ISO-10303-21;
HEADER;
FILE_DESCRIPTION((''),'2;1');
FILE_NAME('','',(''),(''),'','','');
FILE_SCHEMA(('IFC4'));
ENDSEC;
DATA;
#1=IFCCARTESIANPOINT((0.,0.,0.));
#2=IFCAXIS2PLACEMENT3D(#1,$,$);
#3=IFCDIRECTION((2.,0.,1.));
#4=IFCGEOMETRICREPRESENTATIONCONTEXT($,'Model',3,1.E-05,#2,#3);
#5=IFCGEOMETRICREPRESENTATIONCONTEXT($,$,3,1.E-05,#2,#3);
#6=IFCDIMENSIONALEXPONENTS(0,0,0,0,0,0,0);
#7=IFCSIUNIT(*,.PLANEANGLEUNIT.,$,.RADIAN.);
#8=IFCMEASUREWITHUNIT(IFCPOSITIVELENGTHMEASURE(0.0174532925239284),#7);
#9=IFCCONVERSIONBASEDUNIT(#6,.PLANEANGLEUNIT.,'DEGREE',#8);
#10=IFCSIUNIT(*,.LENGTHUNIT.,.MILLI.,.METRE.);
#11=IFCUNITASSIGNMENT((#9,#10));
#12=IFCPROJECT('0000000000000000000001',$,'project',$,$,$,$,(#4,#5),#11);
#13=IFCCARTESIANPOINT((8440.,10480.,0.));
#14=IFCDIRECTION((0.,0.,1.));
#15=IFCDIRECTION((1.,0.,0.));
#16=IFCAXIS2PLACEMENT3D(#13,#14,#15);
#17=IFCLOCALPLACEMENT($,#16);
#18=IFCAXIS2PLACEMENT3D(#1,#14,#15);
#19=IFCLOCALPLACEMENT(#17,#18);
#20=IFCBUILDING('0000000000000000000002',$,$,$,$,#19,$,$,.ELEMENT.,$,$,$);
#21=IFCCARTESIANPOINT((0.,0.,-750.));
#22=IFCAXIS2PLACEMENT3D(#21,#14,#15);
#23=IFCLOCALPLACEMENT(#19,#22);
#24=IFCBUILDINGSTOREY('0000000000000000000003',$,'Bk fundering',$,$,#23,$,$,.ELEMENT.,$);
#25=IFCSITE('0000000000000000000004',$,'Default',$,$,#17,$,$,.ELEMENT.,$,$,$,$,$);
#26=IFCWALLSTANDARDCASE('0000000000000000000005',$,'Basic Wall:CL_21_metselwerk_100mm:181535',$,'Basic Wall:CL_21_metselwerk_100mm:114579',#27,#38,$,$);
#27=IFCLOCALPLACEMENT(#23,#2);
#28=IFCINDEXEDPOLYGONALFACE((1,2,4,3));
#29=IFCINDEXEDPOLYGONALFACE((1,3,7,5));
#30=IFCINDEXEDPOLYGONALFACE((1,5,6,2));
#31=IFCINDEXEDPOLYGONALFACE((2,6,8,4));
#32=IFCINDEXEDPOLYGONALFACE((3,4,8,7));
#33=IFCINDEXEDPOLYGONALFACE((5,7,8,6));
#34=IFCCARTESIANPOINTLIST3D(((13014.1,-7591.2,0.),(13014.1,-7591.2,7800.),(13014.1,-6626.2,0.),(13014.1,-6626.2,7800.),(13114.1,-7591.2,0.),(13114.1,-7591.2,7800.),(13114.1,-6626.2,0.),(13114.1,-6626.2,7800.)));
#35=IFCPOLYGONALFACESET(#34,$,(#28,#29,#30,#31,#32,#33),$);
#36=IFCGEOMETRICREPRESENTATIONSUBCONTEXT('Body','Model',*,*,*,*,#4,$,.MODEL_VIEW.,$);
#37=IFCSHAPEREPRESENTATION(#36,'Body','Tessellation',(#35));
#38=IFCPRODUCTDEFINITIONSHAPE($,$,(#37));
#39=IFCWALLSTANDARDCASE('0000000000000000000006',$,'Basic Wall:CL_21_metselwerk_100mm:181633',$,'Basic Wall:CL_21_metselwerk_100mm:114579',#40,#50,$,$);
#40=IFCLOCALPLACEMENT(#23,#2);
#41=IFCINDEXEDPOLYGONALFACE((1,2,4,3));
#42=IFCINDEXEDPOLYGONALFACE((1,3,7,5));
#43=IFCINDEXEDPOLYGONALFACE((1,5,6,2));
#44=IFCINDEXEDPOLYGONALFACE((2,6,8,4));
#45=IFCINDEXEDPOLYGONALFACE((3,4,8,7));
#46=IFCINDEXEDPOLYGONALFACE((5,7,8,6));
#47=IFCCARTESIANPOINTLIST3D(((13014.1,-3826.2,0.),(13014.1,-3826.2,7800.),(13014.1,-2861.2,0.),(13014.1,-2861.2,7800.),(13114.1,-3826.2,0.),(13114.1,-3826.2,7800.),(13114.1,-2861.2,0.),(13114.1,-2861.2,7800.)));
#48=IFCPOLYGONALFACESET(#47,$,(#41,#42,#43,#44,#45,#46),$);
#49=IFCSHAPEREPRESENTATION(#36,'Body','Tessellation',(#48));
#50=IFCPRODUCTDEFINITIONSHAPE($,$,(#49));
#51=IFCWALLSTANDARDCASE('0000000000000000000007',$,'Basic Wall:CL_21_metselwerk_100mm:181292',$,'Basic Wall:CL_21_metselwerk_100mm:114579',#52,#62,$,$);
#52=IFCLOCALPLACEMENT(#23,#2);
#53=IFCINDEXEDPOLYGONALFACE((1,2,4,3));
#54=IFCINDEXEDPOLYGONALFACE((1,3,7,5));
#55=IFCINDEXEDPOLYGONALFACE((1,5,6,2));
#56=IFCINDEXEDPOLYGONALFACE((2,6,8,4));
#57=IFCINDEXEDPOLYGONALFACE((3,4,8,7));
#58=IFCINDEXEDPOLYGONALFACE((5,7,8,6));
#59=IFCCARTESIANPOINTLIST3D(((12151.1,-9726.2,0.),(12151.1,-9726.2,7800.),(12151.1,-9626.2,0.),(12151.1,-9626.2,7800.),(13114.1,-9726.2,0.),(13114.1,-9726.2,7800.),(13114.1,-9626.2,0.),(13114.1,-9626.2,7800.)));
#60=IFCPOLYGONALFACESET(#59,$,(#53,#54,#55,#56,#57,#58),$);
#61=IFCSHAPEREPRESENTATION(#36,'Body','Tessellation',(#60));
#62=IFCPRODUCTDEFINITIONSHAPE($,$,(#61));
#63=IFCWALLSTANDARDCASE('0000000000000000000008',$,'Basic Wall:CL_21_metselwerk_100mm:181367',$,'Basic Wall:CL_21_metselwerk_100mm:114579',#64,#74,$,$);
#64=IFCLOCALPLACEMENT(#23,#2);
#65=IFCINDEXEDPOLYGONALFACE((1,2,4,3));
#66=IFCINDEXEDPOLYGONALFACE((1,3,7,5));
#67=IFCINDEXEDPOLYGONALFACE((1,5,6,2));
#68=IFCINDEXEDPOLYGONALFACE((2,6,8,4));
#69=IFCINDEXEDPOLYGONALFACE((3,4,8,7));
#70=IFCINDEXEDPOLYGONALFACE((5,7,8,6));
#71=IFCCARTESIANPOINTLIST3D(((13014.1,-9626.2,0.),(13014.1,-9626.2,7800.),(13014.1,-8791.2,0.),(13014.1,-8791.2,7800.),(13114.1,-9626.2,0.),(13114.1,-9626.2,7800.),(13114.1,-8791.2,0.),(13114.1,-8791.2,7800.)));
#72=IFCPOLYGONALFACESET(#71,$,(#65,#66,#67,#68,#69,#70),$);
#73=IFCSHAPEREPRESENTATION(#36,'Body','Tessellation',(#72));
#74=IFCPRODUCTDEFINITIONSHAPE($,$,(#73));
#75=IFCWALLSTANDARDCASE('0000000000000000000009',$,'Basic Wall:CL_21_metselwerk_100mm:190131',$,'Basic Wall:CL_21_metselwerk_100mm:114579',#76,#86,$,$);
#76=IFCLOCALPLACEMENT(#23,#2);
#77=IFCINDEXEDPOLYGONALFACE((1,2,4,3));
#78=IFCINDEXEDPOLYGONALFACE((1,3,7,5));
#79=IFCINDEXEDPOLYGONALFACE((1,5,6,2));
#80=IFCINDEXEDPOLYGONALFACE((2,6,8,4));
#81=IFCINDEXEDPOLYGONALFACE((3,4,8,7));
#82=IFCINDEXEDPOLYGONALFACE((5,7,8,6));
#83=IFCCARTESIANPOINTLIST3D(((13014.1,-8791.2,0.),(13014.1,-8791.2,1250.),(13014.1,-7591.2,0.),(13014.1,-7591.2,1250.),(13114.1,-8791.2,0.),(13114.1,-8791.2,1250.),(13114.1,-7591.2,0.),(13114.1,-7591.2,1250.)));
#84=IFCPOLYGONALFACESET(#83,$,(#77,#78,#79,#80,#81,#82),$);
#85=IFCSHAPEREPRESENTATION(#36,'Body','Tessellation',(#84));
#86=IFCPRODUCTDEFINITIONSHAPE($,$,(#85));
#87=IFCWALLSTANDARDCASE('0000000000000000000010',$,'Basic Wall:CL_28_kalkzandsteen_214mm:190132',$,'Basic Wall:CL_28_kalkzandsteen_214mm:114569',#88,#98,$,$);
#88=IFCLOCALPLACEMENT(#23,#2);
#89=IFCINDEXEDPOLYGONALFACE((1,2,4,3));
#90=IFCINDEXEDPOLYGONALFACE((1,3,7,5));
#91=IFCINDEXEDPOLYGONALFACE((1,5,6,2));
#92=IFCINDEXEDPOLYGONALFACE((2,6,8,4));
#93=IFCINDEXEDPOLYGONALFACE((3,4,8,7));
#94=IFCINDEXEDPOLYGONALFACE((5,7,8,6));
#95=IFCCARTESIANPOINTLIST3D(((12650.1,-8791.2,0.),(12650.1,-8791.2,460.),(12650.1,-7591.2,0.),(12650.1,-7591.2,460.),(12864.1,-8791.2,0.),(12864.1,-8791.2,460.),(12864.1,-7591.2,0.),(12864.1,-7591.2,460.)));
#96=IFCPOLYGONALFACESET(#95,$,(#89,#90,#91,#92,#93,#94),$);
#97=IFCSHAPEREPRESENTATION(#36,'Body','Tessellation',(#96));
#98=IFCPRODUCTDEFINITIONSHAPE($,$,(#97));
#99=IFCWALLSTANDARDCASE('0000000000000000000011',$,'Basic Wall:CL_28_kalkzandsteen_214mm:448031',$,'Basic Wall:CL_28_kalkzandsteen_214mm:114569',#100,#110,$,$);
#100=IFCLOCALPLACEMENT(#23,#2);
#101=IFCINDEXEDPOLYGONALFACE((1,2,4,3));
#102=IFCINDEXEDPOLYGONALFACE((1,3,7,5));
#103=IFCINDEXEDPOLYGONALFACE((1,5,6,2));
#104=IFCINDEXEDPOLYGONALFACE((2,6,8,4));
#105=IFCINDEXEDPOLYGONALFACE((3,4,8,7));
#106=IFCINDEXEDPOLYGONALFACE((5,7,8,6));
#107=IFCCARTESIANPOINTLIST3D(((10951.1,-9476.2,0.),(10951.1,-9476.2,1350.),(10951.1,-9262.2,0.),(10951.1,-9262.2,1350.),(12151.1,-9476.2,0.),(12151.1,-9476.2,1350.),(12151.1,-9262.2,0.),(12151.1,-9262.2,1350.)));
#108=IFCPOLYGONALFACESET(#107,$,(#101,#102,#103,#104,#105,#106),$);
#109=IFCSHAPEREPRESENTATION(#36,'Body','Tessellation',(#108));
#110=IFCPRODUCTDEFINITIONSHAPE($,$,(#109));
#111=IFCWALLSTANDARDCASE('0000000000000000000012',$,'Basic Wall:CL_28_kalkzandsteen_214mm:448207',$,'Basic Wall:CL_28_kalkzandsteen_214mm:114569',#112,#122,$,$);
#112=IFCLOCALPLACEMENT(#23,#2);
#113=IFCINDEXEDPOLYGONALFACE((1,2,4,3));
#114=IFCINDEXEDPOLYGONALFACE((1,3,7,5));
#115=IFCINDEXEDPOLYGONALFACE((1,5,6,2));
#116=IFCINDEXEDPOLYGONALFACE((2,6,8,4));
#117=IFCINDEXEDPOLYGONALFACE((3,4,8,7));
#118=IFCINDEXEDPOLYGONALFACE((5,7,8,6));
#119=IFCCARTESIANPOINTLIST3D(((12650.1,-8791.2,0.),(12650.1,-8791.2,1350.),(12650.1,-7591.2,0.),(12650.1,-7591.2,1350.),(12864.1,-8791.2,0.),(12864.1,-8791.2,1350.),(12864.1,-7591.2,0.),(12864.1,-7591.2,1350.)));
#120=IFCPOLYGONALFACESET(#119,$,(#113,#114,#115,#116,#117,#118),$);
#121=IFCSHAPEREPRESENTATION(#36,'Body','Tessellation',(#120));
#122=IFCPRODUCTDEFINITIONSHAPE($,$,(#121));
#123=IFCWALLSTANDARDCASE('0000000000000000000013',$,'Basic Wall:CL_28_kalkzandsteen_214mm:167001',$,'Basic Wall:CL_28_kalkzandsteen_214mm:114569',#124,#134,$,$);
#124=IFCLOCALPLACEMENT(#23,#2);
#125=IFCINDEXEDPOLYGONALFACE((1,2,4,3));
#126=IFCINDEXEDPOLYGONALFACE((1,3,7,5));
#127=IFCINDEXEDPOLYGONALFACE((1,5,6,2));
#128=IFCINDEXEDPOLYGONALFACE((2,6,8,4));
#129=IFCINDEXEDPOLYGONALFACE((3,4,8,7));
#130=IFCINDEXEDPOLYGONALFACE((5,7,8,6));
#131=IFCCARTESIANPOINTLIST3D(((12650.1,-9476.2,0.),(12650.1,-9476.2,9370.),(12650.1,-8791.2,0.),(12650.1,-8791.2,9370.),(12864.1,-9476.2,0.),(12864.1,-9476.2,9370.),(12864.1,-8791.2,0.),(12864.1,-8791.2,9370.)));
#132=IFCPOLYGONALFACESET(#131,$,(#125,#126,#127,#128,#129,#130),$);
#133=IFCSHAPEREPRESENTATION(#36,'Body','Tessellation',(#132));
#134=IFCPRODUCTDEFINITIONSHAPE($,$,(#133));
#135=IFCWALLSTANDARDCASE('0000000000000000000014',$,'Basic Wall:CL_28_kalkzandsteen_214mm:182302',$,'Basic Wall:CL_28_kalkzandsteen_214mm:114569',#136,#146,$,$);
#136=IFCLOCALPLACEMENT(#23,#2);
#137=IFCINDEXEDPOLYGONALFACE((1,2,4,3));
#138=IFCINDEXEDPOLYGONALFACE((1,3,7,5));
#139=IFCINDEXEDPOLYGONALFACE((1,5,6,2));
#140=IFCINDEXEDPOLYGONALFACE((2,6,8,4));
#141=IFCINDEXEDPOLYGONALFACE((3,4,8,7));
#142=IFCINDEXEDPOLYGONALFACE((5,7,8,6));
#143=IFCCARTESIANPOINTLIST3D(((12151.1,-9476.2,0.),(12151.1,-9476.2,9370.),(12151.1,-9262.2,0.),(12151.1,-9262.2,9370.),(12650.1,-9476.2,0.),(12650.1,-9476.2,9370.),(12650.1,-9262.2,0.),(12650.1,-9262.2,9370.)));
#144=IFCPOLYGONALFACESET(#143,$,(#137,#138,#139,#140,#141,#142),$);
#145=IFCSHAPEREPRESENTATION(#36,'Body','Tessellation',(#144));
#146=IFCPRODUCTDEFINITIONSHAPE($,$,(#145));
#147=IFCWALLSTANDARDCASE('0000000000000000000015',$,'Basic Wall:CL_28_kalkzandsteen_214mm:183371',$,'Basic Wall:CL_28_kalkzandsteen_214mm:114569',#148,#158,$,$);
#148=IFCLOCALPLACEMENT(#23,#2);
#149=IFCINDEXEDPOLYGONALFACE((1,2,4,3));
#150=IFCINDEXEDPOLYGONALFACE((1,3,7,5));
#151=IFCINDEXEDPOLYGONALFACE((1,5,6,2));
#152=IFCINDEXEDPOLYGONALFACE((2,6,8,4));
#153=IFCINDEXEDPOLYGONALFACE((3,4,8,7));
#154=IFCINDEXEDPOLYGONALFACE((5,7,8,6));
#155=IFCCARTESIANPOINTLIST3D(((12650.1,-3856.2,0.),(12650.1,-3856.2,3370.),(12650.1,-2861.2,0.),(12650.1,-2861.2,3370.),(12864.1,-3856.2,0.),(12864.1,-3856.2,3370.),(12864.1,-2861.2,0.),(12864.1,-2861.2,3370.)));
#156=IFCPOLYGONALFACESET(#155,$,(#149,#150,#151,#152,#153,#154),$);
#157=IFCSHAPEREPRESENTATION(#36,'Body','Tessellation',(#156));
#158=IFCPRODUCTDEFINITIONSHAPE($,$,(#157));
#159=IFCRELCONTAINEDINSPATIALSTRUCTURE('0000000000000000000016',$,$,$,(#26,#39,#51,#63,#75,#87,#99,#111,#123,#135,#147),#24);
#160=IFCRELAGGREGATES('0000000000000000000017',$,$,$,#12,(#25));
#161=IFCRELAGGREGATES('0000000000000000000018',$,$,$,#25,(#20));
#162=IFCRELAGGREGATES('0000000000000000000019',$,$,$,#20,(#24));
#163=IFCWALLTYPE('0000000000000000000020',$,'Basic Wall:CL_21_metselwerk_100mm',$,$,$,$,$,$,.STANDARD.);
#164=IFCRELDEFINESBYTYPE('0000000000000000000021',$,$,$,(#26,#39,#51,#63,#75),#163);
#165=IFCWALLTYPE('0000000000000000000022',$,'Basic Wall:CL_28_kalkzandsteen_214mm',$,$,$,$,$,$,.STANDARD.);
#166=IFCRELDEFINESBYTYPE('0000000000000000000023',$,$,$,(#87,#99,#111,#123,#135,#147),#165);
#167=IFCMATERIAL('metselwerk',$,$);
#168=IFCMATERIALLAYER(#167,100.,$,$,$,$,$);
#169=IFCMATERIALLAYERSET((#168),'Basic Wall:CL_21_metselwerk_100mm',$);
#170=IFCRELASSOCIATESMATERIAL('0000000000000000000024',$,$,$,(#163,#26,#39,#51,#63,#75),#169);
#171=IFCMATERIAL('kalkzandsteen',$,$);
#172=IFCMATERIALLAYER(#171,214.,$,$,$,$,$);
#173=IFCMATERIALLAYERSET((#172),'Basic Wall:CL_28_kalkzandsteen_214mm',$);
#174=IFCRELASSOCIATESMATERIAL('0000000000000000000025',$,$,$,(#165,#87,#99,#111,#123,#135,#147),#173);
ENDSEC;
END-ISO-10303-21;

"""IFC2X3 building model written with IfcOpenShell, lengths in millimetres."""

from ifc_helpers import new_model, entity, si_unit, converted_unit, direction, frame, frame_2d, origin, origin_with_axes, place, context, subcontext, project, spatial, polyline, rectangle, extrude, clip, bounded_halfspace, source, transform, mapped, material, layer, layer_set, layer_usage, type_object, element, save


model = new_model("IFC2X3")

# Units and contexts
model_context = context("Model", 3, precision=1e-05, world=origin(), true_north=direction((2.0, 0.0, 1.0)))
context_of_model = context(None, 3, precision=1e-05, world=origin(), true_north=direction((2.0, 0.0, 1.0)))
body_context = subcontext(model_context, "Body", "Model", "MODEL_VIEW")
ifc_project = project(units=[converted_unit("PLANEANGLEUNIT", "DEGREE", entity("IfcPositiveLengthMeasure", 0.0174532925239284), si_unit("PLANEANGLEUNIT", "RADIAN"), dimensions=[0, 0, 0, 0, 0, 0, 0]), si_unit("LENGTHUNIT", "METRE", prefix="MILLI")], contexts=[model_context, context_of_model])

# Site, building, storey
site_placement = place(None, frame((8440.0, 10480.0, 0.0), z_axis=(0.0, 0.0, 1.0), x_axis=(1.0, 0.0, 0.0)))
site = spatial("IfcSite", under=ifc_project, at=site_placement, Name="Default", CompositionType="ELEMENT")
building_placement = place(site_placement, origin_with_axes())
building = spatial("IfcBuilding", under=site, at=building_placement, CompositionType="ELEMENT")
storey_placement = place(building_placement, frame((0.0, 0.0, -750.0), z_axis=(0.0, 0.0, 1.0), x_axis=(1.0, 0.0, 0.0)))
storey = spatial("IfcBuildingStorey", under=building, at=storey_placement, Name="Bk fundering", CompositionType="ELEMENT")

# Walls
ifc_material_1 = material(Name="metselwerk")
ifc_layer_1 = layer(ifc_material_1, 100.0)
ifc_layer_set_1 = layer_set([ifc_layer_1], Name="Basic Wall:CL_21_metselwerk_100mm")
ifc_layer_usage_1 = layer_usage(ifc_layer_set_1, "AXIS2", "NEGATIVE", 50.0)
wall_type_1 = type_object("IfcWallType", Name="Basic Wall:CL_21_metselwerk_100mm", PredefinedType="STANDARD", material=ifc_layer_set_1)
shared_shape_1 = source(origin(), body_context, "Body", "SweptSolid", [
    extrude(rectangle(XDim=965.0, YDim=100.0, at=frame_2d((482.5, 0.0), x_axis=(-1.0, 0.0))), origin(), (0.0, 0.0, 1.0), 7800.0),
])
wall_1_placement = place(storey_placement, frame((13064.1, -7591.2, 0.0), z_axis=(0.0, 0.0, 1.0), x_axis=(0.0, 1.0, 0.0)))
element("IfcWallStandardCase", 1, at=wall_1_placement, inside=storey, type_object=wall_type_1, material=ifc_layer_usage_1, Name="Basic Wall:CL_21_metselwerk_100mm:181535", ObjectType="Basic Wall:CL_21_metselwerk_100mm:114579", context=body_context, shape_type="MappedRepresentation", body=[
    mapped(shared_shape_1, transform((0.0, 0.0, 0.0))),
])
ifc_layer_usage_2 = layer_usage(ifc_layer_set_1, "AXIS2", "NEGATIVE", 50.0)
wall_2_placement = place(storey_placement, frame((13064.1, -3826.2, 0.0), z_axis=(0.0, 0.0, 1.0), x_axis=(0.0, 1.0, 0.0)))
element("IfcWallStandardCase", 2, at=wall_2_placement, inside=storey, type_object=wall_type_1, material=ifc_layer_usage_2, Name="Basic Wall:CL_21_metselwerk_100mm:181633", ObjectType="Basic Wall:CL_21_metselwerk_100mm:114579", context=body_context, shape_type="MappedRepresentation", body=[
    mapped(shared_shape_1, transform((0.0, 0.0, 0.0))),
])
ifc_layer_usage_3 = layer_usage(ifc_layer_set_1, "AXIS2", "NEGATIVE", 50.0)
shared_shape_2 = source(origin(), body_context, "Body", "SweptSolid", [
    extrude(rectangle(XDim=963.0, YDim=100.0, at=frame_2d((481.5, 0.0), x_axis=(-1.0, 0.0))), origin(), (0.0, 0.0, 1.0), 7800.0),
])
wall_3_placement = place(storey_placement, frame((12151.1, -9676.2, 0.0), z_axis=(0.0, 0.0, 1.0), x_axis=(1.0, 0.0, 0.0)))
element("IfcWallStandardCase", 3, at=wall_3_placement, inside=storey, type_object=wall_type_1, material=ifc_layer_usage_3, Name="Basic Wall:CL_21_metselwerk_100mm:181292", ObjectType="Basic Wall:CL_21_metselwerk_100mm:114579", context=body_context, shape_type="MappedRepresentation", body=[
    mapped(shared_shape_2, transform((0.0, 0.0, 0.0))),
])
ifc_layer_usage_4 = layer_usage(ifc_layer_set_1, "AXIS2", "NEGATIVE", 50.0)
shared_shape_3 = source(origin(), body_context, "Body", "SweptSolid", [
    extrude(rectangle(XDim=835.0, YDim=100.0, at=frame_2d((417.5, 0.0), x_axis=(-1.0, 0.0))), origin(), (0.0, 0.0, 1.0), 7800.0),
])
wall_4_placement = place(storey_placement, frame((13064.1, -9626.2, 0.0), z_axis=(0.0, 0.0, 1.0), x_axis=(0.0, 1.0, 0.0)))
element("IfcWallStandardCase", 4, at=wall_4_placement, inside=storey, type_object=wall_type_1, material=ifc_layer_usage_4, Name="Basic Wall:CL_21_metselwerk_100mm:181367", ObjectType="Basic Wall:CL_21_metselwerk_100mm:114579", context=body_context, shape_type="MappedRepresentation", body=[
    mapped(shared_shape_3, transform((0.0, 0.0, 0.0))),
])
ifc_layer_usage_5 = layer_usage(ifc_layer_set_1, "AXIS2", "NEGATIVE", 50.0)
shared_shape_4 = source(origin(), body_context, "Body", "SweptSolid", [
    extrude(rectangle(XDim=1200.0, YDim=100.0, at=frame_2d((600.0, 0.0), x_axis=(-1.0, 0.0))), origin(), (0.0, 0.0, 1.0), 1250.0),
])
wall_5_placement = place(storey_placement, frame((13064.1, -8791.2, 0.0), z_axis=(0.0, 0.0, 1.0), x_axis=(0.0, 1.0, 0.0)))
element("IfcWallStandardCase", 5, at=wall_5_placement, inside=storey, type_object=wall_type_1, material=ifc_layer_usage_5, Name="Basic Wall:CL_21_metselwerk_100mm:190131", ObjectType="Basic Wall:CL_21_metselwerk_100mm:114579", context=body_context, shape_type="MappedRepresentation", body=[
    mapped(shared_shape_4, transform((0.0, 0.0, 0.0))),
])
ifc_material_2 = material(Name="kalkzandsteen")
ifc_layer_2 = layer(ifc_material_2, 214.0)
ifc_layer_set_2 = layer_set([ifc_layer_2], Name="Basic Wall:CL_28_kalkzandsteen_214mm")
ifc_layer_usage_6 = layer_usage(ifc_layer_set_2, "AXIS2", "NEGATIVE", 107.0)
wall_type_2 = type_object("IfcWallType", Name="Basic Wall:CL_28_kalkzandsteen_214mm", PredefinedType="STANDARD", material=ifc_layer_set_2)
shared_shape_5 = source(origin(), body_context, "Body", "Clipping", [
    clip(extrude(rectangle(XDim=1200.0, YDim=214.0, at=frame_2d((600.0, 0.0), x_axis=(-1.0, 0.0))), origin(), (0.0, 0.0, 1.0), 460.0), bounded_halfspace(frame((0.0, -107.0, 460.0), z_axis=(0.0, 0.0, -1.0), x_axis=(0.0, -1.0, 0.0)), True, frame((0.0, -107.0, 460.0)), polyline([(0.0, 0.0), (1200.0, 0.0), (1200.0, 214.0), (0.0, 214.0), (0.0, 0.0)]))),
])
wall_6_placement = place(storey_placement, frame((12757.1, -8791.2, 0.0), z_axis=(0.0, 0.0, 1.0), x_axis=(0.0, 1.0, 0.0)))
element("IfcWallStandardCase", 6, at=wall_6_placement, inside=storey, type_object=wall_type_2, material=ifc_layer_usage_6, Name="Basic Wall:CL_28_kalkzandsteen_214mm:190132", ObjectType="Basic Wall:CL_28_kalkzandsteen_214mm:114569", context=body_context, shape_type="MappedRepresentation", body=[
    mapped(shared_shape_5, transform((0.0, 0.0, 0.0))),
])
ifc_layer_usage_7 = layer_usage(ifc_layer_set_2, "AXIS2", "NEGATIVE", 107.0)
shared_shape_6 = source(origin(), body_context, "Body", "SweptSolid", [
    extrude(rectangle(XDim=1200.0, YDim=214.0, at=frame_2d((600.0, 0.0), x_axis=(-1.0, 0.0))), origin(), (0.0, 0.0, 1.0), 1350.0),
])
wall_7_placement = place(storey_placement, frame((10951.1, -9369.2, 0.0), z_axis=(0.0, 0.0, 1.0), x_axis=(1.0, 0.0, 0.0)))
element("IfcWallStandardCase", 7, at=wall_7_placement, inside=storey, type_object=wall_type_2, material=ifc_layer_usage_7, Name="Basic Wall:CL_28_kalkzandsteen_214mm:448031", ObjectType="Basic Wall:CL_28_kalkzandsteen_214mm:114569", context=body_context, shape_type="MappedRepresentation", body=[
    mapped(shared_shape_6, transform((0.0, 0.0, 0.0))),
])
ifc_layer_usage_8 = layer_usage(ifc_layer_set_2, "AXIS2", "NEGATIVE", 107.0)
wall_8_placement = place(storey_placement, frame((12757.1, -8791.2, 0.0), z_axis=(0.0, 0.0, 1.0), x_axis=(0.0, 1.0, 0.0)))
element("IfcWallStandardCase", 8, at=wall_8_placement, inside=storey, type_object=wall_type_2, material=ifc_layer_usage_8, Name="Basic Wall:CL_28_kalkzandsteen_214mm:448207", ObjectType="Basic Wall:CL_28_kalkzandsteen_214mm:114569", context=body_context, shape_type="MappedRepresentation", body=[
    mapped(shared_shape_6, transform((0.0, 0.0, 0.0))),
])
ifc_layer_usage_9 = layer_usage(ifc_layer_set_2, "AXIS2", "NEGATIVE", 107.0)
wall_9_placement = place(storey_placement, frame((12757.1, -9476.2, 0.0), z_axis=(0.0, 0.0, 1.0), x_axis=(0.0, 1.0, 0.0)))
element("IfcWallStandardCase", 9, at=wall_9_placement, inside=storey, type_object=wall_type_2, material=ifc_layer_usage_9, Name="Basic Wall:CL_28_kalkzandsteen_214mm:167001", ObjectType="Basic Wall:CL_28_kalkzandsteen_214mm:114569", context=body_context, shape_type="Clipping", body=[
    clip(extrude(rectangle(XDim=685.0, YDim=214.0, at=frame_2d((342.5, 0.0), x_axis=(-1.0, 0.0))), origin(), (0.0, 0.0, 1.0), 9370.0), bounded_halfspace(frame((0.0, -107.0, 9370.0), z_axis=(0.0, 0.0, -1.0), x_axis=(0.0, -1.0, 0.0)), True, frame((0.0, -107.0, 9370.0)), polyline([(0.0, 0.0), (685.0, 0.0), (685.0, 214.0), (214.0, 214.0), (0.0, 214.0), (0.0, 0.0)]))),
])
ifc_layer_usage_10 = layer_usage(ifc_layer_set_2, "AXIS2", "NEGATIVE", 107.0)
wall_10_placement = place(storey_placement, frame((12151.1, -9369.2, 0.0), z_axis=(0.0, 0.0, 1.0), x_axis=(1.0, 0.0, 0.0)))
element("IfcWallStandardCase", 10, at=wall_10_placement, inside=storey, type_object=wall_type_2, material=ifc_layer_usage_10, Name="Basic Wall:CL_28_kalkzandsteen_214mm:182302", ObjectType="Basic Wall:CL_28_kalkzandsteen_214mm:114569", context=body_context, shape_type="Clipping", body=[
    clip(extrude(rectangle(XDim=499.0, YDim=214.0, at=frame_2d((249.5, 0.0), x_axis=(-1.0, 0.0))), origin(), (0.0, 0.0, 1.0), 9370.0), bounded_halfspace(frame((0.0, -107.0, 9370.0), z_axis=(0.0, 0.0, -1.0), x_axis=(1.0, 0.0, 0.0)), True, frame((0.0, -107.0, 9370.0)), polyline([(0.0, 0.0), (499.0, 0.0), (499.0, 214.0), (0.0, 214.0), (0.0, 0.0)]))),
])
ifc_layer_usage_11 = layer_usage(ifc_layer_set_2, "AXIS2", "NEGATIVE", 107.0)
wall_11_placement = place(storey_placement, frame((12757.1, -3856.2, 0.0), z_axis=(0.0, 0.0, 1.0), x_axis=(0.0, 1.0, 0.0)))
element("IfcWallStandardCase", 11, at=wall_11_placement, inside=storey, type_object=wall_type_2, material=ifc_layer_usage_11, Name="Basic Wall:CL_28_kalkzandsteen_214mm:183371", ObjectType="Basic Wall:CL_28_kalkzandsteen_214mm:114569", context=body_context, shape_type="Clipping", body=[
    clip(extrude(rectangle(XDim=995.0, YDim=214.0, at=frame_2d((497.5, 0.0), x_axis=(-1.0, 0.0))), origin(), (0.0, 0.0, 1.0), 3370.0), bounded_halfspace(frame((0.0, -107.0, 3370.0), z_axis=(0.0, 0.0, -1.0), x_axis=(0.0, -1.0, 0.0)), True, frame((0.0, -107.0, 3370.0)), polyline([(0.0, 0.0), (995.0, 0.0), (995.0, 214.0), (0.0, 214.0), (0.0, 0.0)]))),
])

save(model, "model.ifc")
